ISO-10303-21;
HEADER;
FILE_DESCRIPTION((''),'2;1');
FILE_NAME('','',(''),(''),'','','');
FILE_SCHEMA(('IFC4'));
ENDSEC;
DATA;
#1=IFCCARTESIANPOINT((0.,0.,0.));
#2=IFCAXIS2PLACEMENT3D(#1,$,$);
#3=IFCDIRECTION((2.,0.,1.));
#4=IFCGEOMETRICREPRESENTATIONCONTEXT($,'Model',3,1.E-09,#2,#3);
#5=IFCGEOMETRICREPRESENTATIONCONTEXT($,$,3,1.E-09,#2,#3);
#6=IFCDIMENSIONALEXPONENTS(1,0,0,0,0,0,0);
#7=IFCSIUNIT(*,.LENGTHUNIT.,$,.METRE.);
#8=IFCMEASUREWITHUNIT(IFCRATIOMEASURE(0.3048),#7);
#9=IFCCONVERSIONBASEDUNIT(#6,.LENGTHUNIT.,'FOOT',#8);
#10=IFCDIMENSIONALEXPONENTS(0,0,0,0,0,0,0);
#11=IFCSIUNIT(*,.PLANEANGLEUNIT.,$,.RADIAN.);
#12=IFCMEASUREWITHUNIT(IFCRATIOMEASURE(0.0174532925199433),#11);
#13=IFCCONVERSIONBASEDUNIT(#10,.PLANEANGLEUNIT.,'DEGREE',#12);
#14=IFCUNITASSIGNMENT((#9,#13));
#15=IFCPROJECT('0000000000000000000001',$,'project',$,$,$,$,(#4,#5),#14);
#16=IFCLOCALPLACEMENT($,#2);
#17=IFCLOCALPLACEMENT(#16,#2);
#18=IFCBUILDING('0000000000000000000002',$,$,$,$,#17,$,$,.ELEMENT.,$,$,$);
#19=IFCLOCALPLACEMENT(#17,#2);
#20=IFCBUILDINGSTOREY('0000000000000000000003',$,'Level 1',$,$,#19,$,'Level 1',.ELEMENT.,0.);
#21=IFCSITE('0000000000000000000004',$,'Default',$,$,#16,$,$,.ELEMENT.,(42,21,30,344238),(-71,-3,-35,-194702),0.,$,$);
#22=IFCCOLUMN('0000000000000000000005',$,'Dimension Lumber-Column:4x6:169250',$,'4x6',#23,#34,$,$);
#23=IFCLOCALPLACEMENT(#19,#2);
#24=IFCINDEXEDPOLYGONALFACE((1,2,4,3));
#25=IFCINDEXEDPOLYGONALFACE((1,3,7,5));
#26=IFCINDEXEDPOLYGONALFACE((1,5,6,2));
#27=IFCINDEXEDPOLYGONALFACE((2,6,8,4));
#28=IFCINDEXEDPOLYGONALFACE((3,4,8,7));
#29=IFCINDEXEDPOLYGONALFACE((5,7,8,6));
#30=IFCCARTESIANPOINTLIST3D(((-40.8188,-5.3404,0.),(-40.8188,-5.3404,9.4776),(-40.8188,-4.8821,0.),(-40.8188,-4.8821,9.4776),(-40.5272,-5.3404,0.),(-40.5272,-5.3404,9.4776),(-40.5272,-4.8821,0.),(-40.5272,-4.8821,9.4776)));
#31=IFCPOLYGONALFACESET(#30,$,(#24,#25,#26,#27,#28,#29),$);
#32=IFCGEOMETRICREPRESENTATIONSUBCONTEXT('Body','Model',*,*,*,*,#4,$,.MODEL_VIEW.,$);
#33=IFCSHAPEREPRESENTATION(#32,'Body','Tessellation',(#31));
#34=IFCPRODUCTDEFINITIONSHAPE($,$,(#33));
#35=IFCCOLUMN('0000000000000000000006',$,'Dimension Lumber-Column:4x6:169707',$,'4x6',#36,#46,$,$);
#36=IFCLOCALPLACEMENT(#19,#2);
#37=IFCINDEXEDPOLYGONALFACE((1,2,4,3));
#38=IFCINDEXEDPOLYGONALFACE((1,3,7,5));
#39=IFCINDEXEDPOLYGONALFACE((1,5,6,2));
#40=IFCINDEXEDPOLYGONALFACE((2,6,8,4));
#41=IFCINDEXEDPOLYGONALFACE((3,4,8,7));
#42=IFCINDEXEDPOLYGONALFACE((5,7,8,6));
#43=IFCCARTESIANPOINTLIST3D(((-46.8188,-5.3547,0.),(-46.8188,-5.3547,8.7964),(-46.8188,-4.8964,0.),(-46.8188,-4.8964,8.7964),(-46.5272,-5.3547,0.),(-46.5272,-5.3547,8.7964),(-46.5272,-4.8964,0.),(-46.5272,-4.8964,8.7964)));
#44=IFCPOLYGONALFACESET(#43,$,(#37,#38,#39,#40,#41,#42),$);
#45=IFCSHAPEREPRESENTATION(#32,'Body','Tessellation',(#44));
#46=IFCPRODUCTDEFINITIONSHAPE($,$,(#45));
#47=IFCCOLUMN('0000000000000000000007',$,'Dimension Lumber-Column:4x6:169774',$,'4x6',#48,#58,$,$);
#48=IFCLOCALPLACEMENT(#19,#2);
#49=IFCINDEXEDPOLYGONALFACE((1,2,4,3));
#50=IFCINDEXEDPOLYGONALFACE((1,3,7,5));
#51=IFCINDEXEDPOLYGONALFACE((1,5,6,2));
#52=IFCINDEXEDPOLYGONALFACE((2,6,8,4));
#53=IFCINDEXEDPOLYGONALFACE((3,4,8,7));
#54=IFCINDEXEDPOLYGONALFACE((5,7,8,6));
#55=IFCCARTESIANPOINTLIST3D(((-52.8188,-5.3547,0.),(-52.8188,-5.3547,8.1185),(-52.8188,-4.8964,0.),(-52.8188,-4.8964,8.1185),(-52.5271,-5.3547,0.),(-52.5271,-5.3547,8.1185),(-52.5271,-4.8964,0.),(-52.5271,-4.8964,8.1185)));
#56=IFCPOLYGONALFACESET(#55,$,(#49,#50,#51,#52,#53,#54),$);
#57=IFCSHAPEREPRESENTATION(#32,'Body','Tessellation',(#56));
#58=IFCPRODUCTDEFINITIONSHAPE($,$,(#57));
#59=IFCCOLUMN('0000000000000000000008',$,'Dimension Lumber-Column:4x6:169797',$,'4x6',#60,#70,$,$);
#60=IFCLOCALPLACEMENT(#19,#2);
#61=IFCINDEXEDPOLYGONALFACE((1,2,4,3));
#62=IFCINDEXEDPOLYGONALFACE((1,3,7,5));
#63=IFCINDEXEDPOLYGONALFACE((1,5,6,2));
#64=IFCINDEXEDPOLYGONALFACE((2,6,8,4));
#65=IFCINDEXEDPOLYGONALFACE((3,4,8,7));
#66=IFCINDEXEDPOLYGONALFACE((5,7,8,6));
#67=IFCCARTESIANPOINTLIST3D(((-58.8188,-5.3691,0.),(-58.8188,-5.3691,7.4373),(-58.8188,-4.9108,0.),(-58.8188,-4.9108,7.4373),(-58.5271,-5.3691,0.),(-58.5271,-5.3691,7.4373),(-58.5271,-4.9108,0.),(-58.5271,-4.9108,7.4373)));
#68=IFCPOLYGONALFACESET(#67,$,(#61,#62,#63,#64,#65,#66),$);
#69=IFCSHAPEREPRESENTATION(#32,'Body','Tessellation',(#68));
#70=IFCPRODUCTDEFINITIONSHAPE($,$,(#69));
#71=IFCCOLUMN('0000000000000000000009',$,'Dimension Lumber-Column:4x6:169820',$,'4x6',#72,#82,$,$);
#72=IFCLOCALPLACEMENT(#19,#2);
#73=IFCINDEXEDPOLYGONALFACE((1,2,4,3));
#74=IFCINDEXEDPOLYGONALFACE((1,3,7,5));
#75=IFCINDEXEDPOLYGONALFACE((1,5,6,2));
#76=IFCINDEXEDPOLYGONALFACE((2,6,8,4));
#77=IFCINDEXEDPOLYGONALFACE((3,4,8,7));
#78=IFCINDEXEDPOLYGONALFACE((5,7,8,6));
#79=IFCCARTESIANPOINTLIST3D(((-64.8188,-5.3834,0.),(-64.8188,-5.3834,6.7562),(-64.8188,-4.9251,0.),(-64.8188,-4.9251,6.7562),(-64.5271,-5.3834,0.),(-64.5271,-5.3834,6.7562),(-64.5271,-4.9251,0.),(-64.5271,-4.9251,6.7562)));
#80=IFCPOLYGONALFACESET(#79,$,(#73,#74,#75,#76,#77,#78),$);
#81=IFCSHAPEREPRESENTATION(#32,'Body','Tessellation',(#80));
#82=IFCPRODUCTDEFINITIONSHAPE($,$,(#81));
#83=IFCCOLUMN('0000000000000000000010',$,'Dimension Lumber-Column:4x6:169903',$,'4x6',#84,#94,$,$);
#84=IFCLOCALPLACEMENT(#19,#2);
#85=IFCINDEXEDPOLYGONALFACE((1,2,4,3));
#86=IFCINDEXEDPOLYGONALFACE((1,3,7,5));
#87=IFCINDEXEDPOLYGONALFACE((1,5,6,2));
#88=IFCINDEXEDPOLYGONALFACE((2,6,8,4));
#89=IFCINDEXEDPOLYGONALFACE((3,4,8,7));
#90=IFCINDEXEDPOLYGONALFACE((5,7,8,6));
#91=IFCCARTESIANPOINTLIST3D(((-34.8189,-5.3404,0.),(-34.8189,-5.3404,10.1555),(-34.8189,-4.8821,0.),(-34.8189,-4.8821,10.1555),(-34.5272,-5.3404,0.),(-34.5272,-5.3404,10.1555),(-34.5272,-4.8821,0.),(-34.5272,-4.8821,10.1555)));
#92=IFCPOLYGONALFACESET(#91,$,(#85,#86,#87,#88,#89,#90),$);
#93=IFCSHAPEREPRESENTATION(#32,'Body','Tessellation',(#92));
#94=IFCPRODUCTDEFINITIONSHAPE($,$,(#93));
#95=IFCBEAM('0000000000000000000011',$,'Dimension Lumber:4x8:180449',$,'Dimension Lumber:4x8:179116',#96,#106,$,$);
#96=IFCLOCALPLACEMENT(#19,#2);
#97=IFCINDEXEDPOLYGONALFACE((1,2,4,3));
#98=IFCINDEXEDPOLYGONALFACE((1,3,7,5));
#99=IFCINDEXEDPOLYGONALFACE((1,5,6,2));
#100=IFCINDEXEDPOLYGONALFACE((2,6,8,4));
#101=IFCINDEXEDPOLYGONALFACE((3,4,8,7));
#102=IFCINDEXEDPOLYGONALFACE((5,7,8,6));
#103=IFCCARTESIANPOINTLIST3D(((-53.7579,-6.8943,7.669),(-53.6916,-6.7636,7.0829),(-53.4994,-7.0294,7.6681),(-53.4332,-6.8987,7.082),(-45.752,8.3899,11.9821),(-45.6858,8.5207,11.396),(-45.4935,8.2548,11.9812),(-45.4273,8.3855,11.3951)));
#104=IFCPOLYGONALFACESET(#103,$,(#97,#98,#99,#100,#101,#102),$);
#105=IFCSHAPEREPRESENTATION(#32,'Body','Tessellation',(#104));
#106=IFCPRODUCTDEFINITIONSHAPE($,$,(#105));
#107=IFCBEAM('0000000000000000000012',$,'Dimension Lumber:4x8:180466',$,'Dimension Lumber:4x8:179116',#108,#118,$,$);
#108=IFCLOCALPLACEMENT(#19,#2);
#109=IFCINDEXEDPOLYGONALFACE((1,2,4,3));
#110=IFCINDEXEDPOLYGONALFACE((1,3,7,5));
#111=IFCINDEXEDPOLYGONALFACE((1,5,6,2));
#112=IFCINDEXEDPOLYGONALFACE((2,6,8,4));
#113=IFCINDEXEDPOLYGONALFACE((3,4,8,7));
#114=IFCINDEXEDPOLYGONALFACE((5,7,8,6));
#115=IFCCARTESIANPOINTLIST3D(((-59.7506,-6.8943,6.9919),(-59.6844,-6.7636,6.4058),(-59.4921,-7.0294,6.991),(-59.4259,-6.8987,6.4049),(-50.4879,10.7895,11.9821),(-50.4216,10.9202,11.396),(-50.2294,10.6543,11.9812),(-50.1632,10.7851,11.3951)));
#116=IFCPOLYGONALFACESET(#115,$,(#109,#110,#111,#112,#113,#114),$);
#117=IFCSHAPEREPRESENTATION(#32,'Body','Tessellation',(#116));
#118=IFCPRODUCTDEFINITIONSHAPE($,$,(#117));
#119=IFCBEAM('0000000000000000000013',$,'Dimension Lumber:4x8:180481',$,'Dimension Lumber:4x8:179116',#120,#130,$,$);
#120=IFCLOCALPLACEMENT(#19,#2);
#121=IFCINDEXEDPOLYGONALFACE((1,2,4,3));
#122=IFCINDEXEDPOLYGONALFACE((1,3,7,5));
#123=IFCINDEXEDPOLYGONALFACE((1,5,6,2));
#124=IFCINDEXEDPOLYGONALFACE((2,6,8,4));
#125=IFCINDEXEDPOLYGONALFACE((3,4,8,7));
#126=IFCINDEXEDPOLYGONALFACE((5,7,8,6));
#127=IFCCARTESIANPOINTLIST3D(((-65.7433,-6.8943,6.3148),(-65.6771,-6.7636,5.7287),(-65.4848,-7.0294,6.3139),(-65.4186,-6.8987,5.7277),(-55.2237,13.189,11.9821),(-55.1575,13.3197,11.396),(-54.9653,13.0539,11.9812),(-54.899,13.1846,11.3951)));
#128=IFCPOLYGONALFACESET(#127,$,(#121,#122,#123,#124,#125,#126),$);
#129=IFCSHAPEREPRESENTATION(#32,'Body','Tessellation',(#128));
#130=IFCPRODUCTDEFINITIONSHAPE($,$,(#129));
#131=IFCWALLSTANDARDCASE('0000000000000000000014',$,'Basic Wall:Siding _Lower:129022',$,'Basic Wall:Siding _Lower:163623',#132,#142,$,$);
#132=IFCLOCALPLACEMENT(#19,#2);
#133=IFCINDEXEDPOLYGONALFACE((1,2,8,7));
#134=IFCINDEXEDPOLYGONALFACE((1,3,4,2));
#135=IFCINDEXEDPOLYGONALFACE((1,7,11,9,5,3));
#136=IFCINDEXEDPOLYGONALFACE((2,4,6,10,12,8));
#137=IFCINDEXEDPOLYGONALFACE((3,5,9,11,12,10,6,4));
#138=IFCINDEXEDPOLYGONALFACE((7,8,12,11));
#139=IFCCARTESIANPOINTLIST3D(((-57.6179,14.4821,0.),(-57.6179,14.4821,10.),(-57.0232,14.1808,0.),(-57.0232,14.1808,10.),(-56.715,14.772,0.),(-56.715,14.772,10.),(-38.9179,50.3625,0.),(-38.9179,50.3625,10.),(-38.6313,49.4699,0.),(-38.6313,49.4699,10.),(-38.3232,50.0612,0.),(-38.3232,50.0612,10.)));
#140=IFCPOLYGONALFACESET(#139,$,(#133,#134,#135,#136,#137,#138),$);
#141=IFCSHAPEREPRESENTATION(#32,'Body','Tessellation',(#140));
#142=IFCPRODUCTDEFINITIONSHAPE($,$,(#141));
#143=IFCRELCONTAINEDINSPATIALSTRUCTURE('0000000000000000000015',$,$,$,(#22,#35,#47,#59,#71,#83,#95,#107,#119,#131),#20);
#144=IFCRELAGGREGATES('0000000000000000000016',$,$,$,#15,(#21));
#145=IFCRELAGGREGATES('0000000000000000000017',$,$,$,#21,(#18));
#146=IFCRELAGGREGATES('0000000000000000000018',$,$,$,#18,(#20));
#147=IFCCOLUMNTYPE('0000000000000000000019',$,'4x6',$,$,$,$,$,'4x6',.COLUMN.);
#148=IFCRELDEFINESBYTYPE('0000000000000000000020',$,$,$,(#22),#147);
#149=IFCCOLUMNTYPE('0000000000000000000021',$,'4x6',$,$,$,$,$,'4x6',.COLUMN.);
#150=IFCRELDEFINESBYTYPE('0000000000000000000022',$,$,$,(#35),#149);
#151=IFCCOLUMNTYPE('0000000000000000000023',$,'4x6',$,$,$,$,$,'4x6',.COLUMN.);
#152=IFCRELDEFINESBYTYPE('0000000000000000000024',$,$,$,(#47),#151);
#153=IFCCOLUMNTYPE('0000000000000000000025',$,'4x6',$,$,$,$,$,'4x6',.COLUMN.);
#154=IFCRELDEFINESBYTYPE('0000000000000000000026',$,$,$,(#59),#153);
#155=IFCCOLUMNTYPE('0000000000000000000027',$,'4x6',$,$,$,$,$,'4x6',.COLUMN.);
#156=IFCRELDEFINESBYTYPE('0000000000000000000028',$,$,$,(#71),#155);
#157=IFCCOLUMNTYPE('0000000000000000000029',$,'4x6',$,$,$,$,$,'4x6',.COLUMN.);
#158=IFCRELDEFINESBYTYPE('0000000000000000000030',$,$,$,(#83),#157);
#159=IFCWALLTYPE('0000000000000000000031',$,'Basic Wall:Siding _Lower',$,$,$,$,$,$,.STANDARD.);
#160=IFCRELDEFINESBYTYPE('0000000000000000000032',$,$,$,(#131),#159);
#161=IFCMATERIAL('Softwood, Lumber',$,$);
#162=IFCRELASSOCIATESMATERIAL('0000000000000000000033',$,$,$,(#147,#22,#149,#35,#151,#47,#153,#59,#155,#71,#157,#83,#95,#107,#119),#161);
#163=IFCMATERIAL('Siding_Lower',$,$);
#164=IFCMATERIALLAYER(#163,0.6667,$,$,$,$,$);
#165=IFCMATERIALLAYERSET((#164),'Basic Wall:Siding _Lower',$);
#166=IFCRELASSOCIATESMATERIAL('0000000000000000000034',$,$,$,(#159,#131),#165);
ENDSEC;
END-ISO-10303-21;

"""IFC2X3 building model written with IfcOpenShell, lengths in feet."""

from ifc_helpers import new_model, entity, si_unit, converted_unit, direction, frame, frame_2d, origin, place, context, subcontext, project, spatial, polyline, rectangle, outline, extrude, source, transform, mapped, material, layer, layer_set, layer_usage, type_object, type_shapes, element, save


model = new_model("IFC2X3")

# Units and contexts
model_context = context("Model", 3, precision=1e-09, world=origin(), true_north=direction((2.0, 0.0, 1.0)))
context_of_model = context(None, 3, precision=1e-09, world=origin(), true_north=direction((2.0, 0.0, 1.0)))
body_context = subcontext(model_context, "Body", "Model", "MODEL_VIEW")
ifc_project = project(units=[converted_unit("LENGTHUNIT", "FOOT", entity("IfcRatioMeasure", 0.3048), si_unit("LENGTHUNIT", "METRE"), dimensions=[1, 0, 0, 0, 0, 0, 0]), converted_unit("PLANEANGLEUNIT", "DEGREE", entity("IfcRatioMeasure", 0.0174532925199433), si_unit("PLANEANGLEUNIT", "RADIAN"), dimensions=[0, 0, 0, 0, 0, 0, 0])], contexts=[model_context, context_of_model])

# Site, building, storey
site_placement = place(None, origin())
site = spatial("IfcSite", under=ifc_project, at=site_placement, Name="Default", CompositionType="ELEMENT", RefLatitude=(42, 21, 30, 344238), RefLongitude=(-71, -3, -35, -194702), RefElevation=0.0)
building_placement = place(site_placement, origin())
building = spatial("IfcBuilding", under=site, at=building_placement, CompositionType="ELEMENT")
storey_placement = place(building_placement, origin())
storey = spatial("IfcBuildingStorey", under=building, at=storey_placement, Name="Level 1", LongName="Level 1", CompositionType="ELEMENT", Elevation=0.0)

# Columns
ifc_material_1 = material(Name="Softwood, Lumber")
column_type_1 = type_object("IfcColumnType", Name="4x6", ElementType="4x6", PredefinedType="COLUMN", material=ifc_material_1)
shared_shape_1 = source(origin(), body_context, "Body", "SweptSolid", [
    extrude(rectangle(XDim=0.2917, YDim=0.4583, at=frame_2d((0.0, 0.0), x_axis=(1.0, 0.0))), frame((0.1458, 0.2292, 0.0), z_axis=(0.0, 0.0, 1.0), x_axis=(-1.0, 0.0, 0.0)), (0.0, 0.0, 1.0), 9.4776),
])
type_shapes(column_type_1, [shared_shape_1])
column_1_placement = place(storey_placement, frame((-40.8188, -5.3404, 0.0)))
element("IfcColumn", 1, at=column_1_placement, inside=storey, type_object=column_type_1, material=ifc_material_1, Name="Dimension Lumber-Column:4x6:169250", ObjectType="4x6", context=body_context, shape_type="MappedRepresentation", body=[
    mapped(shared_shape_1, transform((0.0, 0.0, 0.0), scale=1.0)),
])
column_type_2 = type_object("IfcColumnType", Name="4x6", ElementType="4x6", PredefinedType="COLUMN", material=ifc_material_1)
shared_shape_2 = source(origin(), body_context, "Body", "SweptSolid", [
    extrude(rectangle(XDim=0.2917, YDim=0.4583, at=frame_2d((0.0, 0.0), x_axis=(1.0, 0.0))), frame((0.1458, 0.2292, 0.0), z_axis=(0.0, 0.0, 1.0), x_axis=(-1.0, 0.0, 0.0)), (0.0, 0.0, 1.0), 8.7964),
])
type_shapes(column_type_2, [shared_shape_2])
column_2_placement = place(storey_placement, frame((-46.8188, -5.3547, 0.0)))
element("IfcColumn", 2, at=column_2_placement, inside=storey, type_object=column_type_2, material=ifc_material_1, Name="Dimension Lumber-Column:4x6:169707", ObjectType="4x6", context=body_context, shape_type="MappedRepresentation", body=[
    mapped(shared_shape_2, transform((0.0, 0.0, 0.0), scale=1.0)),
])
column_type_3 = type_object("IfcColumnType", Name="4x6", ElementType="4x6", PredefinedType="COLUMN", material=ifc_material_1)
shared_shape_3 = source(origin(), body_context, "Body", "SweptSolid", [
    extrude(rectangle(XDim=0.2917, YDim=0.4583, at=frame_2d((0.0, 0.0), x_axis=(1.0, 0.0))), frame((0.1458, 0.2292, 0.0), z_axis=(0.0, 0.0, 1.0), x_axis=(-1.0, 0.0, 0.0)), (0.0, 0.0, 1.0), 8.1185),
])
type_shapes(column_type_3, [shared_shape_3])
column_3_placement = place(storey_placement, frame((-52.8188, -5.3547, 0.0)))
element("IfcColumn", 3, at=column_3_placement, inside=storey, type_object=column_type_3, material=ifc_material_1, Name="Dimension Lumber-Column:4x6:169774", ObjectType="4x6", context=body_context, shape_type="MappedRepresentation", body=[
    mapped(shared_shape_3, transform((0.0, 0.0, 0.0), scale=1.0)),
])
column_type_4 = type_object("IfcColumnType", Name="4x6", ElementType="4x6", PredefinedType="COLUMN", material=ifc_material_1)
shared_shape_4 = source(origin(), body_context, "Body", "SweptSolid", [
    extrude(rectangle(XDim=0.2917, YDim=0.4583, at=frame_2d((0.0, 0.0), x_axis=(1.0, 0.0))), frame((0.1458, 0.2292, 0.0), z_axis=(0.0, 0.0, 1.0), x_axis=(-1.0, 0.0, 0.0)), (0.0, 0.0, 1.0), 7.4373),
])
type_shapes(column_type_4, [shared_shape_4])
column_4_placement = place(storey_placement, frame((-58.8188, -5.3691, 0.0)))
element("IfcColumn", 4, at=column_4_placement, inside=storey, type_object=column_type_4, material=ifc_material_1, Name="Dimension Lumber-Column:4x6:169797", ObjectType="4x6", context=body_context, shape_type="MappedRepresentation", body=[
    mapped(shared_shape_4, transform((0.0, 0.0, 0.0), scale=1.0)),
])
column_type_5 = type_object("IfcColumnType", Name="4x6", ElementType="4x6", PredefinedType="COLUMN", material=ifc_material_1)
shared_shape_5 = source(origin(), body_context, "Body", "SweptSolid", [
    extrude(rectangle(XDim=0.2917, YDim=0.4583, at=frame_2d((0.0, 0.0), x_axis=(1.0, 0.0))), frame((0.1458, 0.2292, 0.0), z_axis=(0.0, 0.0, 1.0), x_axis=(-1.0, 0.0, 0.0)), (0.0, 0.0, 1.0), 6.7562),
])
type_shapes(column_type_5, [shared_shape_5])
column_5_placement = place(storey_placement, frame((-64.8188, -5.3834, 0.0)))
element("IfcColumn", 5, at=column_5_placement, inside=storey, type_object=column_type_5, material=ifc_material_1, Name="Dimension Lumber-Column:4x6:169820", ObjectType="4x6", context=body_context, shape_type="MappedRepresentation", body=[
    mapped(shared_shape_5, transform((0.0, 0.0, 0.0), scale=1.0)),
])
column_type_6 = type_object("IfcColumnType", Name="4x6", ElementType="4x6", PredefinedType="COLUMN", material=ifc_material_1)
shared_shape_6 = source(origin(), body_context, "Body", "SweptSolid", [
    extrude(rectangle(XDim=0.2917, YDim=0.4583, at=frame_2d((0.0, 0.0), x_axis=(1.0, 0.0))), frame((0.1458, 0.2292, 0.0), z_axis=(0.0, 0.0, 1.0), x_axis=(-1.0, 0.0, 0.0)), (0.0, 0.0, 1.0), 10.1555),
])
type_shapes(column_type_6, [shared_shape_6])
column_6_placement = place(storey_placement, frame((-34.8189, -5.3404, 0.0)))
element("IfcColumn", 6, at=column_6_placement, inside=storey, type_object=column_type_6, material=ifc_material_1, Name="Dimension Lumber-Column:4x6:169903", ObjectType="4x6", context=body_context, shape_type="MappedRepresentation", body=[
    mapped(shared_shape_6, transform((0.0, 0.0, 0.0), scale=1.0)),
])

# Beams
beam_1_placement = place(storey_placement, frame((-45.6228, 8.3224, 11.9817), z_axis=(-0.112527, -0.214828, 0.970148), x_axis=(-0.450148, -0.859391, -0.242515)))
element("IfcBeam", 7, at=beam_1_placement, inside=storey, material=ifc_material_1, Name="Dimension Lumber:4x8:180449", ObjectType="Dimension Lumber:4x8:179116", context=body_context, shape_type="SweptSolid", body=[
    extrude(rectangle(XDim=0.6042, YDim=0.2917, at=frame_2d((0.0, 0.0), x_axis=(0.0, 1.0))), frame((0.0, -0.001, -0.3021), z_axis=(1.0, 0.0, 0.0), x_axis=(0.0, -0.999995, 0.003283)), (0.0, 0.0, 1.0), 17.7849),
])
beam_2_placement = place(storey_placement, frame((-50.3586, 10.7219, 11.9817), z_axis=(-0.112527, -0.214828, 0.970148), x_axis=(-0.450148, -0.859391, -0.242515)))
element("IfcBeam", 8, at=beam_2_placement, inside=storey, material=ifc_material_1, Name="Dimension Lumber:4x8:180466", ObjectType="Dimension Lumber:4x8:179116", context=body_context, shape_type="SweptSolid", body=[
    extrude(rectangle(XDim=0.6042, YDim=0.2917, at=frame_2d((0.0, 0.0), x_axis=(0.0, 1.0))), frame((0.0, -0.001, -0.3021), z_axis=(1.0, 0.0, 0.0), x_axis=(0.0, -0.999995, 0.003283)), (0.0, 0.0, 1.0), 20.5771),
])
beam_3_placement = place(storey_placement, frame((-55.0945, 13.1214, 11.9817), z_axis=(-0.112527, -0.214828, 0.970148), x_axis=(-0.450148, -0.859391, -0.242515)))
element("IfcBeam", 9, at=beam_3_placement, inside=storey, material=ifc_material_1, Name="Dimension Lumber:4x8:180481", ObjectType="Dimension Lumber:4x8:179116", context=body_context, shape_type="SweptSolid", body=[
    extrude(rectangle(XDim=0.6042, YDim=0.2917, at=frame_2d((0.0, 0.0), x_axis=(0.0, 1.0))), frame((0.0, -0.001, -0.3021), z_axis=(1.0, 0.0, 0.0), x_axis=(0.0, -0.999995, 0.003283)), (0.0, 0.0, 1.0), 23.3692),
])

# Wall
ifc_material_2 = material(Name="Siding_Lower")
ifc_layer = layer(ifc_material_2, 0.6667)
ifc_layer_set = layer_set([ifc_layer], Name="Basic Wall:Siding _Lower")
ifc_layer_usage_1 = layer_usage(ifc_layer_set, "AXIS2", "NEGATIVE", 0.3333)
wall_type = type_object("IfcWallType", Name="Basic Wall:Siding _Lower", PredefinedType="STANDARD", material=ifc_layer_set)
wall_1_placement = place(storey_placement, frame((-57.3223, 14.328, 0.0), z_axis=(0.0, 0.0, 1.0), x_axis=(0.462173, 0.88679, 0.0)))
element("IfcWallStandardCase", 10, at=wall_1_placement, inside=storey, type_object=wall_type, material=ifc_layer_usage_1, Name="Basic Wall:Siding _Lower:129022", ObjectType="Basic Wall:Siding _Lower:163623", context=body_context, shape_type="SweptSolid", body=[
    extrude(outline(polyline([(40.4686, -0.3333), (40.461, 0.3333), (0.0, 0.3333), (0.0077, -0.3333), (0.6744, -0.3333), (39.8019, -0.3333), (40.4686, -0.3333)])), origin(), (0.0, 0.0, 1.0), 10.0),
])

save(model, "model.ifc")
